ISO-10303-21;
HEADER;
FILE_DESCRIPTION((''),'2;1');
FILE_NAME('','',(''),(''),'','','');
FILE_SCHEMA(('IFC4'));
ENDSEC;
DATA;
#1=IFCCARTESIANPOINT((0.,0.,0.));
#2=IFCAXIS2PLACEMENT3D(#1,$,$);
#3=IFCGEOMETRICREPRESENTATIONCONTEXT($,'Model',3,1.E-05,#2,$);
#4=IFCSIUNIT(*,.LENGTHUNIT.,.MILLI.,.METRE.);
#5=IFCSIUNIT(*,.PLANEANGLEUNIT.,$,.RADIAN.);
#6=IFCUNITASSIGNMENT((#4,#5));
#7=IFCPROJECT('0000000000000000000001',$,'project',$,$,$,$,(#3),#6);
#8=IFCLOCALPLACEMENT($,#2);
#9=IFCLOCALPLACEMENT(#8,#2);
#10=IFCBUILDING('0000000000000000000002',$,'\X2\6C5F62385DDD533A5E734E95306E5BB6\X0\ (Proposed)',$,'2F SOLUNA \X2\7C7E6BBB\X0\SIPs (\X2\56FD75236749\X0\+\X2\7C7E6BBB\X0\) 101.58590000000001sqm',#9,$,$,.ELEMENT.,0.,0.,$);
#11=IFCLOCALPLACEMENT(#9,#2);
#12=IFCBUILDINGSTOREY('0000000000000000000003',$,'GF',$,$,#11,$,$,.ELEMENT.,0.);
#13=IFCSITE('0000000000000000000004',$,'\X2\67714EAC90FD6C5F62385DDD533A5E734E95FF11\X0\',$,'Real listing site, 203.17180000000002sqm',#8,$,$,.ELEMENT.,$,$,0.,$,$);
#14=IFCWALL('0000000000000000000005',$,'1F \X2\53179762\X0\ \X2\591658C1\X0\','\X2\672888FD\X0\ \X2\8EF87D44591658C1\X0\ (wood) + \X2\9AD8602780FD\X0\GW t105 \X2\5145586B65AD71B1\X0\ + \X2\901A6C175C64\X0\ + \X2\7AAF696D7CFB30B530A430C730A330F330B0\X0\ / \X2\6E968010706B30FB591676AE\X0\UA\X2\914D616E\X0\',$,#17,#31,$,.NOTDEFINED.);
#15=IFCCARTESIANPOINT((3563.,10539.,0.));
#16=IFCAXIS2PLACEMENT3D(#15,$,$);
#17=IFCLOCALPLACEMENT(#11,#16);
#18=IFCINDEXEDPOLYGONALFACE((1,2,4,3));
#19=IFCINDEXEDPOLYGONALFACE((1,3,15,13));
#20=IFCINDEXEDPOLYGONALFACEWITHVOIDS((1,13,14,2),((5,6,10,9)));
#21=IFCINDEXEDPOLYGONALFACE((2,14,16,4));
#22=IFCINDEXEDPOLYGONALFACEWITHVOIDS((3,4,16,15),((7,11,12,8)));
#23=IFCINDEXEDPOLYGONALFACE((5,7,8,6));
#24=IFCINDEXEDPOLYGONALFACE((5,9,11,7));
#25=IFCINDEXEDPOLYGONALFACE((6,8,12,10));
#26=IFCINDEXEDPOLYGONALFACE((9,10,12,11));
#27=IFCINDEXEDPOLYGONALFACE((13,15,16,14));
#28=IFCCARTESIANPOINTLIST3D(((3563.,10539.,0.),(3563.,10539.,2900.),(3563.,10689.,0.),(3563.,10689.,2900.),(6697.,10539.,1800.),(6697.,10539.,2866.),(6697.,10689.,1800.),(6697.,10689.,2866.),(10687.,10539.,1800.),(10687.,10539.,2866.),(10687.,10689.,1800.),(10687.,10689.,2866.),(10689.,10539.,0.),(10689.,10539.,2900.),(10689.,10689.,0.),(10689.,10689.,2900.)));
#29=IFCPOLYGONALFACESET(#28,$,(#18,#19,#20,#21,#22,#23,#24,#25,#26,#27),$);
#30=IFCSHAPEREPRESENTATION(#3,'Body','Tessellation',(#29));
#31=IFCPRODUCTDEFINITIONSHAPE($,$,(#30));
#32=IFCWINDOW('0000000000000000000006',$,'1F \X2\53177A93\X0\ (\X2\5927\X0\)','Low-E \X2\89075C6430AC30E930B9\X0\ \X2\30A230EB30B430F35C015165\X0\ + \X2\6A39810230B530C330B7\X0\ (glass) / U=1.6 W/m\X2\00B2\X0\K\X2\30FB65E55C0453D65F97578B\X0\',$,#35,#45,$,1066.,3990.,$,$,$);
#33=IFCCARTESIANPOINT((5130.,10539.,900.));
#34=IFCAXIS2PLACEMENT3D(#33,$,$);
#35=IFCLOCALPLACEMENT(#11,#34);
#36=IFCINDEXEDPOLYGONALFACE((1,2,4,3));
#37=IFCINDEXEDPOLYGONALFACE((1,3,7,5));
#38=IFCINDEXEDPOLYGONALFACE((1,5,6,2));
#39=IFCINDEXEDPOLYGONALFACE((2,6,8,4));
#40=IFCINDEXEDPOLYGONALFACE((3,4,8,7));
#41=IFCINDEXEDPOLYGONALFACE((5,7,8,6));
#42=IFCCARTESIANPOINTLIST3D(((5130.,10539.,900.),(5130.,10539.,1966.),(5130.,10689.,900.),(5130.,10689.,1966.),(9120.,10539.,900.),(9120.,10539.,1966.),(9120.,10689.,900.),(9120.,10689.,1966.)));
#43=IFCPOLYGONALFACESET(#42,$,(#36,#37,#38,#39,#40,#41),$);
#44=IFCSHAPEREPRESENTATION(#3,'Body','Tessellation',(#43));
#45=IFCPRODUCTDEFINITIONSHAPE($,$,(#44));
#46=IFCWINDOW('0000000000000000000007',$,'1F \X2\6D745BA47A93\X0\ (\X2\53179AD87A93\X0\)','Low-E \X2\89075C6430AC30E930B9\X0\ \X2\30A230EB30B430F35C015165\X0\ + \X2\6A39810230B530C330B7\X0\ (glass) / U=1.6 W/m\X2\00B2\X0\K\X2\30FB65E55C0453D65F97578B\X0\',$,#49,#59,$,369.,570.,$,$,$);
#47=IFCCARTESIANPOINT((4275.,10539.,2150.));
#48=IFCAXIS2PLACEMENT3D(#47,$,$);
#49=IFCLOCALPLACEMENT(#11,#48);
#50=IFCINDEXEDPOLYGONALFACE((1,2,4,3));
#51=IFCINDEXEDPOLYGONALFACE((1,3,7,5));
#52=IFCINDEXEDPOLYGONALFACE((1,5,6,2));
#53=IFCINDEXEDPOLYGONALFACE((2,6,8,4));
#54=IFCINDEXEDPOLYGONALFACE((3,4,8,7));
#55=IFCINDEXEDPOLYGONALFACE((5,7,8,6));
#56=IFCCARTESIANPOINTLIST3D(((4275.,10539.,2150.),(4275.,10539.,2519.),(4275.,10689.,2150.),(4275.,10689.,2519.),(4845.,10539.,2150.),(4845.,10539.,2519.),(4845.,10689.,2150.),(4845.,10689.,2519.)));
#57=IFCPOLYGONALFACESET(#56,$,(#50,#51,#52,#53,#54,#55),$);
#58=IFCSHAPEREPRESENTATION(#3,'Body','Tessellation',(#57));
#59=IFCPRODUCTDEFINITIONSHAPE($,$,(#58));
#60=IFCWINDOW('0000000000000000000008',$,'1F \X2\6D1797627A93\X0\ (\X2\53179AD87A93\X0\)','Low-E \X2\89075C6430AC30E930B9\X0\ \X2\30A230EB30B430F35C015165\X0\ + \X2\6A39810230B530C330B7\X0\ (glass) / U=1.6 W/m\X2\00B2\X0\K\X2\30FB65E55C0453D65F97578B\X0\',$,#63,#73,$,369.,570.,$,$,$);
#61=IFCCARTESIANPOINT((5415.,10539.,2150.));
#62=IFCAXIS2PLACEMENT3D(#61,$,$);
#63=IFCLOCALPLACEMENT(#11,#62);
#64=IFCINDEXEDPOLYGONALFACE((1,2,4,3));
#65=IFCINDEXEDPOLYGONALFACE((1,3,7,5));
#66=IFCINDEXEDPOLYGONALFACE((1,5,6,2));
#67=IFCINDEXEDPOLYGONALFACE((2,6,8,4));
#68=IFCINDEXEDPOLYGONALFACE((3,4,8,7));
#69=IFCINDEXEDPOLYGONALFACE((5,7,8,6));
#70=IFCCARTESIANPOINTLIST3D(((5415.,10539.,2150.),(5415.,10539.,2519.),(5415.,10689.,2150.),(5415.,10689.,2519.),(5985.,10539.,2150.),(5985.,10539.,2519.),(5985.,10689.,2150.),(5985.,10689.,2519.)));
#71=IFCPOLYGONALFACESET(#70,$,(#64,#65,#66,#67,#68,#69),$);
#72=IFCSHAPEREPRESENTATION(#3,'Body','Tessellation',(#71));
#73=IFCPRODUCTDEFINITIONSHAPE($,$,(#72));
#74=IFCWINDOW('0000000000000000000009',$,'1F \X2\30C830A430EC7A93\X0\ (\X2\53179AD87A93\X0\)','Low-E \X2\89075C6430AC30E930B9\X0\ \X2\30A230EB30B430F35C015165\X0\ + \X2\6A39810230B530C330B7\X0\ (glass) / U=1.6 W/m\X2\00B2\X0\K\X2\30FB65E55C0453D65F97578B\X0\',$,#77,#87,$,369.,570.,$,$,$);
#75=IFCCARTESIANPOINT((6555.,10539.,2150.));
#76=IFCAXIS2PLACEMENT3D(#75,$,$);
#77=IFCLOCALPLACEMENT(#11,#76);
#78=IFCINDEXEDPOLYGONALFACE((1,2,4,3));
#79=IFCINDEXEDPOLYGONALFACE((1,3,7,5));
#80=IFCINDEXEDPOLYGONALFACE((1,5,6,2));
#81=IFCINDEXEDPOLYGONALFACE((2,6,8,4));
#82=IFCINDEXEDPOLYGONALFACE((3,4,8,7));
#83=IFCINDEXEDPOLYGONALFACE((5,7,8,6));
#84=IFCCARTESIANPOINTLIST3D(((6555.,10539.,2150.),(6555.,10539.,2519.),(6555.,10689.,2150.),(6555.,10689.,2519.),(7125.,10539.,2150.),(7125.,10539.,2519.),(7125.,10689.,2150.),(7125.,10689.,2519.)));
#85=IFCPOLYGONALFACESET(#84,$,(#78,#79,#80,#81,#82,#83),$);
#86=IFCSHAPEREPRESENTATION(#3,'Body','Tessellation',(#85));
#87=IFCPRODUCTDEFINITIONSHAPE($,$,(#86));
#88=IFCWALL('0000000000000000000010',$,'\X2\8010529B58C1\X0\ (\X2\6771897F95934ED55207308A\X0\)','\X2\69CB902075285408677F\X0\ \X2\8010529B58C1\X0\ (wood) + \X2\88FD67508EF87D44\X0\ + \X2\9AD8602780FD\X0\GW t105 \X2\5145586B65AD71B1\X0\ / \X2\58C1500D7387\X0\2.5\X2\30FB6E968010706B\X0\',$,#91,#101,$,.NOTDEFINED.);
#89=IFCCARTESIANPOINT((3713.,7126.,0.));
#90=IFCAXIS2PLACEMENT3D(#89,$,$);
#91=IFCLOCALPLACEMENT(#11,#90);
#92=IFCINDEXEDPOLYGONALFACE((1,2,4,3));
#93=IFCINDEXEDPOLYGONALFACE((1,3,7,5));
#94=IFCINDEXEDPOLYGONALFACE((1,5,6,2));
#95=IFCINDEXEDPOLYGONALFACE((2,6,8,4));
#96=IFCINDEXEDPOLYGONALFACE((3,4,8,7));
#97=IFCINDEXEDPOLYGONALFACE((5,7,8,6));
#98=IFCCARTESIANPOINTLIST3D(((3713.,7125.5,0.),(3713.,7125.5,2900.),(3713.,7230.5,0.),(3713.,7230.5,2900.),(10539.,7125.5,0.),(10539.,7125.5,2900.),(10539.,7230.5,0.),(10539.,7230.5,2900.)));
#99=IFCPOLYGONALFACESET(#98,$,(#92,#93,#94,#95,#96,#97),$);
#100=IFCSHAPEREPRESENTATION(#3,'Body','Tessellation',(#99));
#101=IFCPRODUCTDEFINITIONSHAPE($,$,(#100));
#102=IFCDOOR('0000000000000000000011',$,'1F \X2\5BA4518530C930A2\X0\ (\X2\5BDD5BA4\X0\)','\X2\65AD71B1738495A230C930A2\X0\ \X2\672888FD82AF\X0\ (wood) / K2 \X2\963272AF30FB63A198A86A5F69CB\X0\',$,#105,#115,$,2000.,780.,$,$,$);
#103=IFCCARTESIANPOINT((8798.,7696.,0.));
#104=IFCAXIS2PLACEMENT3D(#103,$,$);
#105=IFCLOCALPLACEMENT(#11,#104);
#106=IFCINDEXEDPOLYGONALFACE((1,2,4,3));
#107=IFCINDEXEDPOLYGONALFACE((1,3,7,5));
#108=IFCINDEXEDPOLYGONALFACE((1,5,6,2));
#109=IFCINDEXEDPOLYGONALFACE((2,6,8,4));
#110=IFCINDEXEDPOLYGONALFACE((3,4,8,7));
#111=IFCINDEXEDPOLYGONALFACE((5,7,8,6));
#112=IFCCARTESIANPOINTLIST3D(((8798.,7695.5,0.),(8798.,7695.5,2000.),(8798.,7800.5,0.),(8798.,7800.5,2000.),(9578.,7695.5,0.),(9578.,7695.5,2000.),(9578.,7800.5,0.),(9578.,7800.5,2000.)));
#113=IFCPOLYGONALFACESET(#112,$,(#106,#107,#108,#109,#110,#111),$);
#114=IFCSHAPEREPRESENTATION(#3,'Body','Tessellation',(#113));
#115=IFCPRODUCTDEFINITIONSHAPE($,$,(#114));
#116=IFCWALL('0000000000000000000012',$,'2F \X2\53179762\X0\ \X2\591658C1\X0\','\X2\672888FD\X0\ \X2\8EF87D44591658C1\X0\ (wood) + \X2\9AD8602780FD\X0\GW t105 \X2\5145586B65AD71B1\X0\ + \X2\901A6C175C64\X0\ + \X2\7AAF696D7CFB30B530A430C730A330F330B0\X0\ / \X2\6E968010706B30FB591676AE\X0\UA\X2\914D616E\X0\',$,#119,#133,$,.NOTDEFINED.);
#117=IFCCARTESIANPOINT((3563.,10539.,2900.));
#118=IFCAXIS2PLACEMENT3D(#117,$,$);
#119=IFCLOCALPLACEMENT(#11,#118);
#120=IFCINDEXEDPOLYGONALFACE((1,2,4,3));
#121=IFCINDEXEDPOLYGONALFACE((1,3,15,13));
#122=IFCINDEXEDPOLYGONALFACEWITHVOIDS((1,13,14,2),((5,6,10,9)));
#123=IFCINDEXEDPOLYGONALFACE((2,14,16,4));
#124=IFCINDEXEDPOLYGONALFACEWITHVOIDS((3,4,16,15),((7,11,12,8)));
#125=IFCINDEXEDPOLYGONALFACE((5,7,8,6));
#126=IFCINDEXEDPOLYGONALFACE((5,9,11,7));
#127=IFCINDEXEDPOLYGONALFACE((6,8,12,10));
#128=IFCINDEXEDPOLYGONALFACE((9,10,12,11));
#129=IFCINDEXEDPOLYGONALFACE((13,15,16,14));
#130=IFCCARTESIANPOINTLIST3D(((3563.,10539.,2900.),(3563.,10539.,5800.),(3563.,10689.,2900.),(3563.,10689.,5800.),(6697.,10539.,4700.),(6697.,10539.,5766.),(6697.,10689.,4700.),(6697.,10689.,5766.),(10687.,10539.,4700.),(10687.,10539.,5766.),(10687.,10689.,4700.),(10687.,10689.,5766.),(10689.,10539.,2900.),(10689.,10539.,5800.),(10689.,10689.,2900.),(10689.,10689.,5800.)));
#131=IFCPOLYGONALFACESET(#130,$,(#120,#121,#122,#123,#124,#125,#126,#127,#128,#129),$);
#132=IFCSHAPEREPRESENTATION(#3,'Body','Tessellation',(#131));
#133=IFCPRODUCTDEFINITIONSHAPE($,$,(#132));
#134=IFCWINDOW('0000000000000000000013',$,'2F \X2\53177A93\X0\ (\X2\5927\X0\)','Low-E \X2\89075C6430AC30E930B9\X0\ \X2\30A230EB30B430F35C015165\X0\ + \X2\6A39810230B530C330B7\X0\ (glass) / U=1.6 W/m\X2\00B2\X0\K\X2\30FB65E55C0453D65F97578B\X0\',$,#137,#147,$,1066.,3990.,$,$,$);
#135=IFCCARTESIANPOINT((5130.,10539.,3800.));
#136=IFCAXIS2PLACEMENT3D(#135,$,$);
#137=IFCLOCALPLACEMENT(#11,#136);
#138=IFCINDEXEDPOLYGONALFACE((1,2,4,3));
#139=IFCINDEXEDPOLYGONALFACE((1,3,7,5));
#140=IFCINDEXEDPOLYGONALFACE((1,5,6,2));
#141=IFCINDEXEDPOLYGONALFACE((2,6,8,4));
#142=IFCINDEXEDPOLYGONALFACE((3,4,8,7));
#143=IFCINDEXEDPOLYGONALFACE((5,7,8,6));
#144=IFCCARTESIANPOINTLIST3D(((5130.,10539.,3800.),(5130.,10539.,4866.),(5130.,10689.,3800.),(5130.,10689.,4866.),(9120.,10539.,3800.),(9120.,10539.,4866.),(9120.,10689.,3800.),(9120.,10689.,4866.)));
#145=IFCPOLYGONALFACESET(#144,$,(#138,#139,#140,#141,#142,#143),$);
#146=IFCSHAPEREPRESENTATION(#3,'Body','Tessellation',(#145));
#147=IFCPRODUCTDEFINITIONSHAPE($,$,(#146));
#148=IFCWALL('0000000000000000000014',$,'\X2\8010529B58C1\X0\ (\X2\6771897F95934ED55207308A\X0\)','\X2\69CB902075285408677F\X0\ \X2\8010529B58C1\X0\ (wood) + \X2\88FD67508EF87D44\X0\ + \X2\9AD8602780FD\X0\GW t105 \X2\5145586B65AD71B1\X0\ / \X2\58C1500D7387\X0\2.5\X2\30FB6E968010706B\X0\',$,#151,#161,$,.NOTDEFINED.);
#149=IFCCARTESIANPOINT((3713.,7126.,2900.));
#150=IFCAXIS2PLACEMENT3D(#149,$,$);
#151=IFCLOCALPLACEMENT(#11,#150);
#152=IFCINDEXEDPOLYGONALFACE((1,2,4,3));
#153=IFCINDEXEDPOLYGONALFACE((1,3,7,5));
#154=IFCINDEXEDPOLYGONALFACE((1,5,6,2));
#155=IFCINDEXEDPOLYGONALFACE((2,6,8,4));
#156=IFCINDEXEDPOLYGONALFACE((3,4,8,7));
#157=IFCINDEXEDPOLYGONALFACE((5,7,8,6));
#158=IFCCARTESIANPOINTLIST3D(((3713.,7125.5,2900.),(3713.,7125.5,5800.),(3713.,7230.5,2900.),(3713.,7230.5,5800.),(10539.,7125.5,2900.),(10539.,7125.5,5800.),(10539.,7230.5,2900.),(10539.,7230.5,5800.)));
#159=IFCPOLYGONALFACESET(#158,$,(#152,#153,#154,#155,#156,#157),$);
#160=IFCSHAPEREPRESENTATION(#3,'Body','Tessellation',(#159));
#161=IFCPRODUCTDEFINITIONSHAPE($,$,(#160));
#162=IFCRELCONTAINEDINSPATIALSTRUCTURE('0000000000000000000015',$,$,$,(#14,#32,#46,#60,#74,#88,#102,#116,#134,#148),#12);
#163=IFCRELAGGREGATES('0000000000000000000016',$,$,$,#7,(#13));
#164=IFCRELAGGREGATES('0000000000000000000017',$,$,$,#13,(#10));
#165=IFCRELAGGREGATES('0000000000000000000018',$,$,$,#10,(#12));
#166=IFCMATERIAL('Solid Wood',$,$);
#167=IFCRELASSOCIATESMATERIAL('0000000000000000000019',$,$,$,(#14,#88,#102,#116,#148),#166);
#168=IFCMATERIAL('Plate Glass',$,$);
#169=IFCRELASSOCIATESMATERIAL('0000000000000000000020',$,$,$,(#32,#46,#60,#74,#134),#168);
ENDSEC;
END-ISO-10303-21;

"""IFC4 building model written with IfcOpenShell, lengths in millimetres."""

from ifc_helpers import new_model, si_unit, frame, frame_2d, origin, place, context, project, spatial, rectangle, extrude, material, element, fill, save


model = new_model("IFC4")

# Units and contexts
model_context = context("Model", 3, precision=1e-05, world=origin())
ifc_project = project(units=[si_unit("LENGTHUNIT", "METRE", prefix="MILLI"), si_unit("PLANEANGLEUNIT", "RADIAN")], contexts=[model_context])

# Site, building, storey
site_placement = place(None, origin())
site = spatial("IfcSite", under=ifc_project, at=site_placement, Name="東京都江戸川区平井１", ObjectType="Real listing site, 203.17180000000002sqm", CompositionType="ELEMENT", RefElevation=0.0)
building_placement = place(site_placement, origin())
building = spatial("IfcBuilding", under=site, at=building_placement, Name="江戸川区平井の家 (Proposed)", ObjectType="2F SOLUNA 籾殻SIPs (国産杉+籾殻) 101.58590000000001sqm", CompositionType="ELEMENT", ElevationOfRefHeight=0.0, ElevationOfTerrain=0.0)
storey_placement = place(building_placement, origin())
storey = spatial("IfcBuildingStorey", under=building, at=storey_placement, Name="GF", CompositionType="ELEMENT", Elevation=0.0)

# Wall, openings, windows
ifc_material_1 = material(Name="Solid Wood")
wall_1_placement = place(storey_placement, frame((3563.0, 10539.0, 0.0)))
wall_1 = element("IfcWall", 1, at=wall_1_placement, inside=storey, material=ifc_material_1, Name="1F 北面 外壁", Description="木製 軸組外壁 (wood) + 高性能GW t105 充填断熱 + 通気層 + 窯業系サイディング / 準耐火・外皮UA配慮", PredefinedType="NOTDEFINED", context=model_context, shape_type="SweptSolid", body=[
    extrude(rectangle(XDim=7126.0, YDim=150.0, at=frame_2d((3563.0, 75.0))), frame((3563.0, 10539.0, 0.0)), (0.0, 0.0, 1.0), 2900.0),
])
opening_1_placement = place(storey_placement, frame((5130.0, 10539.0, 900.0)))
opening_1 = element("IfcOpeningElement", 2, at=opening_1_placement, cuts=wall_1, PredefinedType="NOTDEFINED", context=model_context, shape_type="SweptSolid", body=[
    extrude(rectangle(XDim=3990.0, YDim=150.0, at=frame_2d((1995.0, 75.0))), frame((5130.0, 10539.0, 900.0)), (0.0, 0.0, 1.0), 1066.0),
])
opening_2_placement = place(storey_placement, frame((4275.0, 10539.0, 2150.0)))
opening_2 = element("IfcOpeningElement", 3, at=opening_2_placement, cuts=wall_1, PredefinedType="NOTDEFINED", context=model_context, shape_type="SweptSolid", body=[
    extrude(rectangle(XDim=570.0, YDim=150.0, at=frame_2d((285.0, 75.0))), frame((4275.0, 10539.0, 2150.0)), (0.0, 0.0, 1.0), 369.0),
])
opening_3_placement = place(storey_placement, frame((5415.0, 10539.0, 2150.0)))
opening_3 = element("IfcOpeningElement", 4, at=opening_3_placement, cuts=wall_1, PredefinedType="NOTDEFINED", context=model_context, shape_type="SweptSolid", body=[
    extrude(rectangle(XDim=570.0, YDim=150.0, at=frame_2d((285.0, 75.0))), frame((5415.0, 10539.0, 2150.0)), (0.0, 0.0, 1.0), 369.0),
])
opening_4_placement = place(storey_placement, frame((6555.0, 10539.0, 2150.0)))
opening_4 = element("IfcOpeningElement", 5, at=opening_4_placement, cuts=wall_1, PredefinedType="NOTDEFINED", context=model_context, shape_type="SweptSolid", body=[
    extrude(rectangle(XDim=570.0, YDim=150.0, at=frame_2d((285.0, 75.0))), frame((6555.0, 10539.0, 2150.0)), (0.0, 0.0, 1.0), 369.0),
])
ifc_material_2 = material(Name="Plate Glass")
window_1_placement = place(storey_placement, frame((5130.0, 10539.0, 900.0)))
window_1 = element("IfcWindow", 6, at=window_1_placement, inside=storey, material=ifc_material_2, Name="1F 北窓 (大)", Description="Low-E 複層ガラス アルゴン封入 + 樹脂サッシ (glass) / U=1.6 W/m²K・日射取得型", OverallHeight=1066.0, OverallWidth=3990.0, context=model_context, shape_type="SweptSolid", body=[
    extrude(rectangle(XDim=3990.0, YDim=150.0, at=frame_2d((1995.0, 75.0))), frame((5130.0, 10539.0, 900.0)), (0.0, 0.0, 1.0), 1066.0),
])
fill(opening_1, window_1)
window_2_placement = place(storey_placement, frame((4275.0, 10539.0, 2150.0)))
window_2 = element("IfcWindow", 7, at=window_2_placement, inside=storey, material=ifc_material_2, Name="1F 浴室窓 (北高窓)", Description="Low-E 複層ガラス アルゴン封入 + 樹脂サッシ (glass) / U=1.6 W/m²K・日射取得型", OverallHeight=369.0, OverallWidth=570.0, context=model_context, shape_type="SweptSolid", body=[
    extrude(rectangle(XDim=570.0, YDim=150.0, at=frame_2d((285.0, 75.0))), frame((4275.0, 10539.0, 2150.0)), (0.0, 0.0, 1.0), 369.0),
])
fill(opening_2, window_2)
window_3_placement = place(storey_placement, frame((5415.0, 10539.0, 2150.0)))
window_3 = element("IfcWindow", 8, at=window_3_placement, inside=storey, material=ifc_material_2, Name="1F 洗面窓 (北高窓)", Description="Low-E 複層ガラス アルゴン封入 + 樹脂サッシ (glass) / U=1.6 W/m²K・日射取得型", OverallHeight=369.0, OverallWidth=570.0, context=model_context, shape_type="SweptSolid", body=[
    extrude(rectangle(XDim=570.0, YDim=150.0, at=frame_2d((285.0, 75.0))), frame((5415.0, 10539.0, 2150.0)), (0.0, 0.0, 1.0), 369.0),
])
fill(opening_3, window_3)
window_4_placement = place(storey_placement, frame((6555.0, 10539.0, 2150.0)))
window_4 = element("IfcWindow", 9, at=window_4_placement, inside=storey, material=ifc_material_2, Name="1F トイレ窓 (北高窓)", Description="Low-E 複層ガラス アルゴン封入 + 樹脂サッシ (glass) / U=1.6 W/m²K・日射取得型", OverallHeight=369.0, OverallWidth=570.0, context=model_context, shape_type="SweptSolid", body=[
    extrude(rectangle(XDim=570.0, YDim=150.0, at=frame_2d((285.0, 75.0))), frame((6555.0, 10539.0, 2150.0)), (0.0, 0.0, 1.0), 369.0),
])
fill(opening_4, window_4)

# Wall
wall_2_placement = place(storey_placement, frame((3713.0, 7126.0, 0.0)))
element("IfcWall", 10, at=wall_2_placement, inside=storey, material=ifc_material_1, Name="耐力壁 (東西間仕切り)", Description="構造用合板 耐力壁 (wood) + 製材軸組 + 高性能GW t105 充填断熱 / 壁倍率2.5・準耐火", PredefinedType="NOTDEFINED", context=model_context, shape_type="SweptSolid", body=[
    extrude(rectangle(XDim=6826.0, YDim=105.0, at=frame_2d((3413.0, 52.0))), frame((3713.0, 7126.0, 0.0)), (0.0, 0.0, 1.0), 2900.0),
])

# Door
door_1_placement = place(storey_placement, frame((8798.0, 7696.0, 0.0)))
element("IfcDoor", 11, at=door_1_placement, inside=storey, material=ifc_material_1, Name="1F 室内ドア (寝室)", Description="断熱玄関ドア 木製芯 (wood) / K2 防犯・採風機構", OverallHeight=2000.0, OverallWidth=780.0, context=model_context, shape_type="SweptSolid", body=[
    extrude(rectangle(XDim=780.0, YDim=105.0, at=frame_2d((390.0, 52.0))), frame((8798.0, 7696.0, 0.0)), (0.0, 0.0, 1.0), 2000.0),
])

# Wall, opening, window
wall_3_placement = place(storey_placement, frame((3563.0, 10539.0, 2900.0)))
wall_3 = element("IfcWall", 12, at=wall_3_placement, inside=storey, material=ifc_material_1, Name="2F 北面 外壁", Description="木製 軸組外壁 (wood) + 高性能GW t105 充填断熱 + 通気層 + 窯業系サイディング / 準耐火・外皮UA配慮", PredefinedType="NOTDEFINED", context=model_context, shape_type="SweptSolid", body=[
    extrude(rectangle(XDim=7126.0, YDim=150.0, at=frame_2d((3563.0, 75.0))), frame((3563.0, 10539.0, 2900.0)), (0.0, 0.0, 1.0), 2900.0),
])
opening_5_placement = place(storey_placement, frame((5130.0, 10539.0, 3800.0)))
opening_5 = element("IfcOpeningElement", 13, at=opening_5_placement, cuts=wall_3, PredefinedType="NOTDEFINED", context=model_context, shape_type="SweptSolid", body=[
    extrude(rectangle(XDim=3990.0, YDim=150.0, at=frame_2d((1995.0, 75.0))), frame((5130.0, 10539.0, 3800.0)), (0.0, 0.0, 1.0), 1066.0),
])
window_5_placement = place(storey_placement, frame((5130.0, 10539.0, 3800.0)))
window_5 = element("IfcWindow", 14, at=window_5_placement, inside=storey, material=ifc_material_2, Name="2F 北窓 (大)", Description="Low-E 複層ガラス アルゴン封入 + 樹脂サッシ (glass) / U=1.6 W/m²K・日射取得型", OverallHeight=1066.0, OverallWidth=3990.0, context=model_context, shape_type="SweptSolid", body=[
    extrude(rectangle(XDim=3990.0, YDim=150.0, at=frame_2d((1995.0, 75.0))), frame((5130.0, 10539.0, 3800.0)), (0.0, 0.0, 1.0), 1066.0),
])
fill(opening_5, window_5)

# Wall
wall_4_placement = place(storey_placement, frame((3713.0, 7126.0, 2900.0)))
element("IfcWall", 15, at=wall_4_placement, inside=storey, material=ifc_material_1, Name="耐力壁 (東西間仕切り)", Description="構造用合板 耐力壁 (wood) + 製材軸組 + 高性能GW t105 充填断熱 / 壁倍率2.5・準耐火", PredefinedType="NOTDEFINED", context=model_context, shape_type="SweptSolid", body=[
    extrude(rectangle(XDim=6826.0, YDim=105.0, at=frame_2d((3413.0, 52.0))), frame((3713.0, 7126.0, 2900.0)), (0.0, 0.0, 1.0), 2900.0),
])

save(model, "model.ifc")
